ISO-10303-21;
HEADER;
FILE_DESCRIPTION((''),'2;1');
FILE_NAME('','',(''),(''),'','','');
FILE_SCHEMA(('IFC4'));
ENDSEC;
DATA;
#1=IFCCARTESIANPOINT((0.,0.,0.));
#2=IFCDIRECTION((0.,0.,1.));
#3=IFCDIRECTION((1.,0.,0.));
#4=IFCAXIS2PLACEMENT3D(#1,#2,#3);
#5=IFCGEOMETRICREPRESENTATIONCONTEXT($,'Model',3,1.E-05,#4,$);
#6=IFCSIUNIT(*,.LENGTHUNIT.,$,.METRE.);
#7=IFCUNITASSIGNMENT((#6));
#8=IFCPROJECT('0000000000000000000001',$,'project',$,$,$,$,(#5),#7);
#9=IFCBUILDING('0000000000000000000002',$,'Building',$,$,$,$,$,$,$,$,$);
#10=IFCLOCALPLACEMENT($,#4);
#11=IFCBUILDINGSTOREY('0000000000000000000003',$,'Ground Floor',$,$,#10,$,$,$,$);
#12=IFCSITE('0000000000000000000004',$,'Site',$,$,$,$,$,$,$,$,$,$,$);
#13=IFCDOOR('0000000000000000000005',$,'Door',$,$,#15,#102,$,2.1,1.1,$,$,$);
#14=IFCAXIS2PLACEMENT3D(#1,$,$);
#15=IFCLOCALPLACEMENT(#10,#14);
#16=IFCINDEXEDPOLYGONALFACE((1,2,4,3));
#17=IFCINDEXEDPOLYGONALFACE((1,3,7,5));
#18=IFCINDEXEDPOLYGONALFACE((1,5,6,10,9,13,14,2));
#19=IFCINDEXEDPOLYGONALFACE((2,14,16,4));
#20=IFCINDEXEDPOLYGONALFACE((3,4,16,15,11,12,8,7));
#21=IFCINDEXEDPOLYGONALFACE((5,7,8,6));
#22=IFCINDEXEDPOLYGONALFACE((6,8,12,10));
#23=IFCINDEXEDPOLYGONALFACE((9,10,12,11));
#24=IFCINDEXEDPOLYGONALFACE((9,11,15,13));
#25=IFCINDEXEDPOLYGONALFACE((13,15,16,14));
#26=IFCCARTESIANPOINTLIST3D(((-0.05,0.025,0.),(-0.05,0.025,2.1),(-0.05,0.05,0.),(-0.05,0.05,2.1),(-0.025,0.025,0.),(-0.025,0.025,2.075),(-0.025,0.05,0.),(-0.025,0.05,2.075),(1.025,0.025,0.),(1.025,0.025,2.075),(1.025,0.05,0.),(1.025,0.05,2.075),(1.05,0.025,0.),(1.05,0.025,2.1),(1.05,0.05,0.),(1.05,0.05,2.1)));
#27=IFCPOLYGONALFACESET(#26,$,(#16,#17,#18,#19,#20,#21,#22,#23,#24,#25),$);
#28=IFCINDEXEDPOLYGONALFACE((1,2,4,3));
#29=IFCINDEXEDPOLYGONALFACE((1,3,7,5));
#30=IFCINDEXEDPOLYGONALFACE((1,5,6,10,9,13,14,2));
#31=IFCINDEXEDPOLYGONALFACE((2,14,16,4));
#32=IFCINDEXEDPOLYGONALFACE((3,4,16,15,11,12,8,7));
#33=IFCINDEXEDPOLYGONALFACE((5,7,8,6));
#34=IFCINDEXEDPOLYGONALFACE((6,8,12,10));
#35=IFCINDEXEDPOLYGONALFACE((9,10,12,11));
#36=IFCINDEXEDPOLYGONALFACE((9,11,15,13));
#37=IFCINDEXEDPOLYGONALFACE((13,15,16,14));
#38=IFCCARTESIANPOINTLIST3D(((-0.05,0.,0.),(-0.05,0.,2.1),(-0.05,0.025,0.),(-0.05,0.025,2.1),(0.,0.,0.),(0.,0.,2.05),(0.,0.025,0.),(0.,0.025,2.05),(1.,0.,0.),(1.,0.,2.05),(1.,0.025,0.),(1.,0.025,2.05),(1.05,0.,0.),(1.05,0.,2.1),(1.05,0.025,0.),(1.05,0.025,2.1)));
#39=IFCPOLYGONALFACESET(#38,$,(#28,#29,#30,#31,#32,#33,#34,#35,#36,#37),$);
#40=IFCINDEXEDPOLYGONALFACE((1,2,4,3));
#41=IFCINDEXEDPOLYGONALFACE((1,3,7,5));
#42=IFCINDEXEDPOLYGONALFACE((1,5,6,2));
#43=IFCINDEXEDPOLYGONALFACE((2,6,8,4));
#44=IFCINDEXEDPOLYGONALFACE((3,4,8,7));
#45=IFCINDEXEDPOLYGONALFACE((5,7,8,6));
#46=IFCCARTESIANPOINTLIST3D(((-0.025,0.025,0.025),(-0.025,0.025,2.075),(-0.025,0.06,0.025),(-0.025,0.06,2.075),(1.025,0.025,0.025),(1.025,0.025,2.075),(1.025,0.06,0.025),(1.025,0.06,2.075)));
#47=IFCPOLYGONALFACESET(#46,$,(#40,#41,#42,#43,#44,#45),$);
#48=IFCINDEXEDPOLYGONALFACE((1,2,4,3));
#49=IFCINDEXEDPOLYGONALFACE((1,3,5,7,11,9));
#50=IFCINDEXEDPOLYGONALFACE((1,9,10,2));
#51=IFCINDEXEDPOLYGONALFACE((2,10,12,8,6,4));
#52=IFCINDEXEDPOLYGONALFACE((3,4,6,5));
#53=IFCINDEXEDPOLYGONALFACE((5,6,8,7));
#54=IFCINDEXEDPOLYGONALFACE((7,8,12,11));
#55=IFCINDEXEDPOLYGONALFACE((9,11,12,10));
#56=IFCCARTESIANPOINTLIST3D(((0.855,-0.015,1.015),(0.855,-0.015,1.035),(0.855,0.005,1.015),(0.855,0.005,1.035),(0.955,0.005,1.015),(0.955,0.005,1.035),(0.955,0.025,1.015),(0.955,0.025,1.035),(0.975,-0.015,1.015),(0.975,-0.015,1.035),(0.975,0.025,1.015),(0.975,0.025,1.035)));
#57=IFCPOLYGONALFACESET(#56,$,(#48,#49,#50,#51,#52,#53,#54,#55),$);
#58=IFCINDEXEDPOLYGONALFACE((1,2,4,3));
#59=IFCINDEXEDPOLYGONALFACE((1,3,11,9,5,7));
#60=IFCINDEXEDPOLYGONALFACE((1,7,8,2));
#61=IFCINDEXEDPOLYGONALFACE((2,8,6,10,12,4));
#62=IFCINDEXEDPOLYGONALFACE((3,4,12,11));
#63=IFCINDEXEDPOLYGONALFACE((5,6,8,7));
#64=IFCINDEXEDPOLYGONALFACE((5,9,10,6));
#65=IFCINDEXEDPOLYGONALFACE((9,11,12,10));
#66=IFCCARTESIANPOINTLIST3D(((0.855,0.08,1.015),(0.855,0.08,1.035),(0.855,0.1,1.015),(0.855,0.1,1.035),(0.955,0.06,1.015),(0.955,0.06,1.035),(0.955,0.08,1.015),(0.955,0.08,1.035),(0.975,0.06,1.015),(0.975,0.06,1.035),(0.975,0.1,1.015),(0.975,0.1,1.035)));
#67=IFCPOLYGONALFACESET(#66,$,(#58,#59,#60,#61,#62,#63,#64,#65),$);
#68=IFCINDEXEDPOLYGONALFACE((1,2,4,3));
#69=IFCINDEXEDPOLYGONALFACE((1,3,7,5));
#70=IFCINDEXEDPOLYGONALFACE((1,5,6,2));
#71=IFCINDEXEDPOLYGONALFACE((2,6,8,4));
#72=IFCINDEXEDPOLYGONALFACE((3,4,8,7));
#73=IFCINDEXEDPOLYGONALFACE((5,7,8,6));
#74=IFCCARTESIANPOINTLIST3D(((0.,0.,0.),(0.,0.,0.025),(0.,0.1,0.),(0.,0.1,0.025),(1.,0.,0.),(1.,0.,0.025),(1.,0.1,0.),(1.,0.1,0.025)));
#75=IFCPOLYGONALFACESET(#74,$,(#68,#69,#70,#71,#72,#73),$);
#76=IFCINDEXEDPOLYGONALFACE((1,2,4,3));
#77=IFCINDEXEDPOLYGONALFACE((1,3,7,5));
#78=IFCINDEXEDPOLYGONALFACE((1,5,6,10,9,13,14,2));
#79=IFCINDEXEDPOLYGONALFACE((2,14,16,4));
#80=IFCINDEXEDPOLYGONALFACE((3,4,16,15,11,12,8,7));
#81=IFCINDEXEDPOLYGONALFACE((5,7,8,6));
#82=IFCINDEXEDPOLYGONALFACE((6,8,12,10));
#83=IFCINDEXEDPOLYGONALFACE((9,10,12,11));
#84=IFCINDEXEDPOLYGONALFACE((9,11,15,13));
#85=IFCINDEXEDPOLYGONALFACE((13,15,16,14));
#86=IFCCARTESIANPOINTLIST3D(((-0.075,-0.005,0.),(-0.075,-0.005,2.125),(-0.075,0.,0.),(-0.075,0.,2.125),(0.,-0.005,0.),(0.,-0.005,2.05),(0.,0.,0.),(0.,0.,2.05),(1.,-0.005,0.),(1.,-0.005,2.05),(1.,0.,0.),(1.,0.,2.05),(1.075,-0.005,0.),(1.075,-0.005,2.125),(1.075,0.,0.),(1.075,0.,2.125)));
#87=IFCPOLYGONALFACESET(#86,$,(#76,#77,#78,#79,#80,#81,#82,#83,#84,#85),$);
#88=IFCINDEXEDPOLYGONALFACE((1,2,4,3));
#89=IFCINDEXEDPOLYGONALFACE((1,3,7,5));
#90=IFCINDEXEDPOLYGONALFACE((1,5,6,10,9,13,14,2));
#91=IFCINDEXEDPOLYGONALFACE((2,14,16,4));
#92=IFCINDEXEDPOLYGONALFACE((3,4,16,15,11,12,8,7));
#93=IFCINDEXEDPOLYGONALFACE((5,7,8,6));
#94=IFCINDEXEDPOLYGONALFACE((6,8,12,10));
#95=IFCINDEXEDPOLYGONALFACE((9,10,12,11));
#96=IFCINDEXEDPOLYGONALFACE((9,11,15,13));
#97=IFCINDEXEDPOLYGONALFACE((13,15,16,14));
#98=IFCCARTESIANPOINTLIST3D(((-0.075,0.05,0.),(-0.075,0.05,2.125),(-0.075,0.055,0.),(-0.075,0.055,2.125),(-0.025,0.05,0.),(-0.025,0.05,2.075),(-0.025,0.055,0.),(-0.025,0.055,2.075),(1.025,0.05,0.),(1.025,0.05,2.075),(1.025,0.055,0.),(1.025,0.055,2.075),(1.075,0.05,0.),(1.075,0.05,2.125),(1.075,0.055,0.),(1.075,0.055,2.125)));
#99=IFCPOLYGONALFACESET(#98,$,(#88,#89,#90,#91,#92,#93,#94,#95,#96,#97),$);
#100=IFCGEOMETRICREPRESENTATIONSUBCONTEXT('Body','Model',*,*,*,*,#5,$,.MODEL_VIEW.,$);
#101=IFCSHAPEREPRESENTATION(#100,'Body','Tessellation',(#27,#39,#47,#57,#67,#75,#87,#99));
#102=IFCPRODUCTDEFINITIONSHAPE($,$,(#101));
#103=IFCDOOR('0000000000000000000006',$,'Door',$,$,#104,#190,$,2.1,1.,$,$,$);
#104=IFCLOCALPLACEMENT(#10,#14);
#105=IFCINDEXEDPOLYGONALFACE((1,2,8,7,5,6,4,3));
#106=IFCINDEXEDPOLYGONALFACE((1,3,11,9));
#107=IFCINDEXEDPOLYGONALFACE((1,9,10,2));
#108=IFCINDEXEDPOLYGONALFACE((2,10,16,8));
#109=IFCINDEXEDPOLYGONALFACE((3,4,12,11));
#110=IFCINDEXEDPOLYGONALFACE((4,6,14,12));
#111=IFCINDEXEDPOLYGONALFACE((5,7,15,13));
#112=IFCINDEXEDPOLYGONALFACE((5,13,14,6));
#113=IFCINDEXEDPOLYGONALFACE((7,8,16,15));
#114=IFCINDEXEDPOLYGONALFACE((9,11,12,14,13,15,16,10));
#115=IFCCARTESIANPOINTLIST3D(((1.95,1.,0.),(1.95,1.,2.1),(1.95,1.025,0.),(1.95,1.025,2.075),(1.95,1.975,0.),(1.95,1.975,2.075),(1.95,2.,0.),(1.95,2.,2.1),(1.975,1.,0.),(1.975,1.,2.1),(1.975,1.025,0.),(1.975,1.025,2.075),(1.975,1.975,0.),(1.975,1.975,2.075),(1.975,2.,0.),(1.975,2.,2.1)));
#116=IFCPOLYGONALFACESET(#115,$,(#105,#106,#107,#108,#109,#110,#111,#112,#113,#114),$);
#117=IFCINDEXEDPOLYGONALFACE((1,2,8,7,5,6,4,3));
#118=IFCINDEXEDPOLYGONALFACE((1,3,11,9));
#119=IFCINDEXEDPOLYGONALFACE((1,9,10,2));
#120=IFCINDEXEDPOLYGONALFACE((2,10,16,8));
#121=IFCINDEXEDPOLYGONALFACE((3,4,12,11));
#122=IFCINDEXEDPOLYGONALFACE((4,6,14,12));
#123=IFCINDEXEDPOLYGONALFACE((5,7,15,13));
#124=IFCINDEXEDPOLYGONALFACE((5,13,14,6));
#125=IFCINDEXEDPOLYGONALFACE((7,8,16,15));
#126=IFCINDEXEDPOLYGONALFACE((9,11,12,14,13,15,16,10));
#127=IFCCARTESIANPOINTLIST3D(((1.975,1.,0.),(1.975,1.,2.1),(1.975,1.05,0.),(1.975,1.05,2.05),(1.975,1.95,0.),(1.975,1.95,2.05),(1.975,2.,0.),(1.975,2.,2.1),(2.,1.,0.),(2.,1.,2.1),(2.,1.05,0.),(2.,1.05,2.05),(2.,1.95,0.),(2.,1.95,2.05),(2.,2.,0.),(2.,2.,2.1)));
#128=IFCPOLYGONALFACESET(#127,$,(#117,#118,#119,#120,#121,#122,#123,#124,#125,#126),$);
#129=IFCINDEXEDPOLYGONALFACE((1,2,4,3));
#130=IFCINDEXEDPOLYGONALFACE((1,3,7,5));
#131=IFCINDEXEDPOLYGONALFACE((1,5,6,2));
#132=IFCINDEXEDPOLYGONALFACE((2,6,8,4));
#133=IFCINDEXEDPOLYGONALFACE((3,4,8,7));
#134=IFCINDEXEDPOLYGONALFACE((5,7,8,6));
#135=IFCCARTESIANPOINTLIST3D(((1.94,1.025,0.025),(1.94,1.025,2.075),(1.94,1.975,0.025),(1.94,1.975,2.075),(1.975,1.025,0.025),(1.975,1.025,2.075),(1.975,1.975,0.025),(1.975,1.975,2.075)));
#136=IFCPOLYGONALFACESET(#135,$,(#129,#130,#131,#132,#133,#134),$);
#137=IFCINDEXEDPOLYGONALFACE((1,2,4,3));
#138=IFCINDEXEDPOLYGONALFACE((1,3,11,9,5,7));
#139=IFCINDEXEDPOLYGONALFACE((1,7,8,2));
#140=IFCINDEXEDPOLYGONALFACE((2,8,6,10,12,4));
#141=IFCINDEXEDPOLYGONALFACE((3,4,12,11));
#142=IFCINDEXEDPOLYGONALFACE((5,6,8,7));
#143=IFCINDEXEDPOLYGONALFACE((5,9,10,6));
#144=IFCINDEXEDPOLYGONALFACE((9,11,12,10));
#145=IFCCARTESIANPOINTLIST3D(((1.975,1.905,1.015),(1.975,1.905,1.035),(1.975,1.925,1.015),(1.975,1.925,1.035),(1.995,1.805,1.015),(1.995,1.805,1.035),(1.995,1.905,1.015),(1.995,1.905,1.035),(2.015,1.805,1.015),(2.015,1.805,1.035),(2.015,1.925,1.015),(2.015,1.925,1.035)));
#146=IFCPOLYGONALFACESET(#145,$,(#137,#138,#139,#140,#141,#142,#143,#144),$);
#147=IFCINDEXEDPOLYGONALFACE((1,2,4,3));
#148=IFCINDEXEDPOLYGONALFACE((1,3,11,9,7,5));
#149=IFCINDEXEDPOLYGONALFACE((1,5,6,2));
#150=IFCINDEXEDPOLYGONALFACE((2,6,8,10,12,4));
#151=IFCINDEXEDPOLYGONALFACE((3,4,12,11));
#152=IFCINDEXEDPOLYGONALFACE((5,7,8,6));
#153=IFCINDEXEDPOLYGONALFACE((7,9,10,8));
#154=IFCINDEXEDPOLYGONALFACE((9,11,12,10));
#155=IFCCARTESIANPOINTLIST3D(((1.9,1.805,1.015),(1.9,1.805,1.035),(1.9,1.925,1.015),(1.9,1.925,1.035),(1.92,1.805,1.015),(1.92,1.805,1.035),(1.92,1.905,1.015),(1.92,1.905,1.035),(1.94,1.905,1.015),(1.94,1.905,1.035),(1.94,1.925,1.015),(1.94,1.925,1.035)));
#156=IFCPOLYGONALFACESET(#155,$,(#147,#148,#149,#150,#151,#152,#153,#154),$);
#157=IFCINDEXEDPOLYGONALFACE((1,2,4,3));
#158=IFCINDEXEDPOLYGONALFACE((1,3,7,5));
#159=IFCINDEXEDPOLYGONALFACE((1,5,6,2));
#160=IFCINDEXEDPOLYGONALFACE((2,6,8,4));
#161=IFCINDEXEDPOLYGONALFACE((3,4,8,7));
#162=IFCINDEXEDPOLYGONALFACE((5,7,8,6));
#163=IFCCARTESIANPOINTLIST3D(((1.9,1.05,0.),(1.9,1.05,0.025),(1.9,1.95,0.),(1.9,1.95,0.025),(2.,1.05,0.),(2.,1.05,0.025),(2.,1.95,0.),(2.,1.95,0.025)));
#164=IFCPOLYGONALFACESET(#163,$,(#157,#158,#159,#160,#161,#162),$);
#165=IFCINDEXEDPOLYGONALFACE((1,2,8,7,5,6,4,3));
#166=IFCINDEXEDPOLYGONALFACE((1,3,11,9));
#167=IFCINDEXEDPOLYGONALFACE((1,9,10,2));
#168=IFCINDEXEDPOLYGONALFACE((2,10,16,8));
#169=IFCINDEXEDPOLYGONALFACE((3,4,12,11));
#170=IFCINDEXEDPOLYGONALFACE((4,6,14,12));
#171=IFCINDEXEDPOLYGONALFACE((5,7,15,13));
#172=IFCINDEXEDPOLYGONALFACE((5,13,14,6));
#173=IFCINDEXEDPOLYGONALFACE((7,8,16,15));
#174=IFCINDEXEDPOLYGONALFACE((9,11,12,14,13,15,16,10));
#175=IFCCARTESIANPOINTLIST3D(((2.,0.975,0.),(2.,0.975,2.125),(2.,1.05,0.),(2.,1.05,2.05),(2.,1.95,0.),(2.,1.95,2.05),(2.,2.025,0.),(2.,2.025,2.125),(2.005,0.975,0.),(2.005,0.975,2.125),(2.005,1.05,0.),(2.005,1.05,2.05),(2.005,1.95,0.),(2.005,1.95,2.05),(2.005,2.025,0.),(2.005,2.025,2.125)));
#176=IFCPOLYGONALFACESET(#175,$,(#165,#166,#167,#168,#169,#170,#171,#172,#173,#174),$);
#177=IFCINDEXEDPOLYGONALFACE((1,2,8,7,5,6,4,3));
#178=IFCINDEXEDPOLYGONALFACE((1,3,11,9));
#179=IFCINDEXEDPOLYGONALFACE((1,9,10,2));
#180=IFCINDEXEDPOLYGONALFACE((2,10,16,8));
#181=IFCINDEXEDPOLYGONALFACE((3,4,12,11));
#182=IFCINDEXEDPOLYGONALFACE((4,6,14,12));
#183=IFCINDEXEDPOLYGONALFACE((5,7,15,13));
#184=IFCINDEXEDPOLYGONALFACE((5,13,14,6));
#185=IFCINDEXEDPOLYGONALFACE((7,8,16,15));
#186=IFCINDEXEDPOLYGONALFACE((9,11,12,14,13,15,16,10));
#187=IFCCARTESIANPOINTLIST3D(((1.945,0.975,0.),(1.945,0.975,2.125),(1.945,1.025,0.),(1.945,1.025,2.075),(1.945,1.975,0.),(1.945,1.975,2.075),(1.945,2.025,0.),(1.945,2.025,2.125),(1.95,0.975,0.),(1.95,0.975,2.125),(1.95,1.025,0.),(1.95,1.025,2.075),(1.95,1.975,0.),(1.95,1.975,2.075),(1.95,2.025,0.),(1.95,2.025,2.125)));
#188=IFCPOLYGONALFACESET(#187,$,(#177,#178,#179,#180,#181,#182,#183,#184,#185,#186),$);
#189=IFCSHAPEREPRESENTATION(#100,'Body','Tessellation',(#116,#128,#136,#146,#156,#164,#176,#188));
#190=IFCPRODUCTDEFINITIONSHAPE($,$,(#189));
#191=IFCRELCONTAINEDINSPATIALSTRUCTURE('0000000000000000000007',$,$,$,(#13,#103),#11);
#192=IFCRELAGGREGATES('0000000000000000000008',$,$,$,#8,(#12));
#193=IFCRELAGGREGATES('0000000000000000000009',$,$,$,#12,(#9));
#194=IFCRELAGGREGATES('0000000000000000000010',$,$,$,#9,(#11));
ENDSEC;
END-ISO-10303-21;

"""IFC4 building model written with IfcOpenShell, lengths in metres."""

from ifc_helpers import new_model, si_unit, frame, origin_with_axes, place, context, subcontext, project, spatial, line, indexed_curve, outline, extrude, element, save


model = new_model("IFC4")

# Units and contexts
model_context = context("Model", 3, precision=1e-05, world=origin_with_axes())
body_context = subcontext(model_context, "Body", "Model", "MODEL_VIEW")
ifc_project = project(units=[si_unit("LENGTHUNIT", "METRE")], contexts=[model_context])

# Site, building, storey
site = spatial("IfcSite", under=ifc_project, Name="Site")
building = spatial("IfcBuilding", under=site, Name="Building")
storey_placement = place(None, origin_with_axes())
storey = spatial("IfcBuildingStorey", under=building, at=storey_placement, Name="Ground Floor")

# Doors
door_1_placement = place(storey_placement, frame((-0.05, 0.0, 0.0), z_axis=(0.0, 0.0, 1.0), x_axis=(1.0, 0.0, 0.0)))
element("IfcDoor", 1, at=door_1_placement, inside=storey, Name="Door", OverallHeight=2.1, OverallWidth=1.1, context=body_context, shape_type="SweptSolid", body=[
    extrude(outline(indexed_curve([(0.0, 0.0), (0.0, 2.1), (1.1, 2.1), (1.1, 0.0), (1.075, 0.0), (1.075, 2.075), (0.025, 2.075), (0.025, 0.0)], segments=[line(1, 2, 3, 4, 5, 6, 7, 8, 1)])), frame((0.0, 0.025, 0.0), z_axis=(0.0, -1.0, 0.0), x_axis=(1.0, 0.0, 0.0)), (0.0, 0.0, -1.0), 0.025),
    extrude(outline(indexed_curve([(0.0, 0.0), (0.0, 2.1), (1.1, 2.1), (1.1, 0.0), (1.05, 0.0), (1.05, 2.05), (0.05, 2.05), (0.05, 0.0)], segments=[line(1, 2, 3, 4, 5, 6, 7, 8, 1)])), frame((0.0, 0.0, 0.0), z_axis=(0.0, -1.0, 0.0), x_axis=(1.0, 0.0, 0.0)), (0.0, 0.0, -1.0), 0.025),
    extrude(outline(indexed_curve([(0.0, 0.0), (1.05, 0.0), (1.05, 0.035), (0.0, 0.035)], segments=[line(1, 2, 3, 4, 1)])), frame((0.025, 0.025, 0.025), z_axis=(0.0, 0.0, 1.0), x_axis=(1.0, 0.0, 0.0)), (0.0, 0.0, 1.0), 2.05),
    extrude(outline(indexed_curve([(0.0, 0.0), (0.0, -0.04), (-0.12, -0.04), (-0.12, -0.02), (-0.02, -0.02), (-0.02, 0.0)], segments=[line(1, 2, 3, 4, 5, 6, 1)])), frame((1.025, 0.025, 1.015), z_axis=(0.0, 0.0, 1.0), x_axis=(1.0, 0.0, 0.0)), (0.0, 0.0, 1.0), 0.02),
    extrude(outline(indexed_curve([(0.0, 0.0), (0.0, 0.04), (-0.12, 0.04), (-0.12, 0.02), (-0.02, 0.02), (-0.02, 0.0)], segments=[line(1, 2, 3, 4, 5, 6, 1)])), frame((1.025, 0.06, 1.015), z_axis=(0.0, 0.0, 1.0), x_axis=(1.0, 0.0, 0.0)), (0.0, 0.0, 1.0), 0.02),
    extrude(outline(indexed_curve([(0.0, 0.0), (1.0, 0.0), (1.0, 0.1), (0.0, 0.1)], segments=[line(1, 2, 3, 4, 1)])), frame((0.05, 0.0, 0.0), z_axis=(0.0, 0.0, 1.0), x_axis=(1.0, 0.0, 0.0)), (0.0, 0.0, 1.0), 0.025),
    extrude(outline(indexed_curve([(0.0, 0.0), (0.0, 2.125), (1.15, 2.125), (1.15, 0.0), (1.075, 0.0), (1.075, 2.05), (0.075, 2.05), (0.075, 0.0)], segments=[line(1, 2, 3, 4, 5, 6, 7, 8, 1)])), frame((-0.025, -0.005, 0.0), z_axis=(0.0, -1.0, 0.0), x_axis=(1.0, 0.0, 0.0)), (0.0, 0.0, -1.0), 0.005),
    extrude(outline(indexed_curve([(0.0, 0.0), (0.0, 2.125), (1.15, 2.125), (1.15, 0.0), (1.1, 0.0), (1.1, 2.075), (0.05, 2.075), (0.05, 0.0)], segments=[line(1, 2, 3, 4, 5, 6, 7, 8, 1)])), frame((-0.025, 0.05, 0.0), z_axis=(0.0, -1.0, 0.0), x_axis=(1.0, 0.0, 0.0)), (0.0, 0.0, -1.0), 0.005),
])
door_2_placement = place(storey_placement, frame((2.0, 1.0, 0.0), z_axis=(0.0, 0.0, 1.0), x_axis=(0.0, 1.0, 0.0)))
element("IfcDoor", 2, at=door_2_placement, inside=storey, Name="Door", OverallHeight=2.1, OverallWidth=1.0, context=body_context, shape_type="SweptSolid", body=[
    extrude(outline(indexed_curve([(0.0, 0.0), (0.0, 2.1), (1.0, 2.1), (1.0, 0.0), (0.975, 0.0), (0.975, 2.075), (0.025, 2.075), (0.025, 0.0)], segments=[line(1, 2, 3, 4, 5, 6, 7, 8, 1)])), frame((0.0, 0.025, 0.0), z_axis=(0.0, -1.0, 0.0), x_axis=(1.0, 0.0, 0.0)), (0.0, 0.0, -1.0), 0.025),
    extrude(outline(indexed_curve([(0.0, 0.0), (0.0, 2.1), (1.0, 2.1), (1.0, 0.0), (0.95, 0.0), (0.95, 2.05), (0.05, 2.05), (0.05, 0.0)], segments=[line(1, 2, 3, 4, 5, 6, 7, 8, 1)])), frame((0.0, 0.0, 0.0), z_axis=(0.0, -1.0, 0.0), x_axis=(1.0, 0.0, 0.0)), (0.0, 0.0, -1.0), 0.025),
    extrude(outline(indexed_curve([(0.0, 0.0), (0.95, 0.0), (0.95, 0.035), (0.0, 0.035)], segments=[line(1, 2, 3, 4, 1)])), frame((0.025, 0.025, 0.025), z_axis=(0.0, 0.0, 1.0), x_axis=(1.0, 0.0, 0.0)), (0.0, 0.0, 1.0), 2.05),
    extrude(outline(indexed_curve([(0.0, 0.0), (0.0, -0.04), (-0.12, -0.04), (-0.12, -0.02), (-0.02, -0.02), (-0.02, 0.0)], segments=[line(1, 2, 3, 4, 5, 6, 1)])), frame((0.925, 0.025, 1.015), z_axis=(0.0, 0.0, 1.0), x_axis=(1.0, 0.0, 0.0)), (0.0, 0.0, 1.0), 0.02),
    extrude(outline(indexed_curve([(0.0, 0.0), (0.0, 0.04), (-0.12, 0.04), (-0.12, 0.02), (-0.02, 0.02), (-0.02, 0.0)], segments=[line(1, 2, 3, 4, 5, 6, 1)])), frame((0.925, 0.06, 1.015), z_axis=(0.0, 0.0, 1.0), x_axis=(1.0, 0.0, 0.0)), (0.0, 0.0, 1.0), 0.02),
    extrude(outline(indexed_curve([(0.0, 0.0), (0.9, 0.0), (0.9, 0.1), (0.0, 0.1)], segments=[line(1, 2, 3, 4, 1)])), frame((0.05, 0.0, 0.0), z_axis=(0.0, 0.0, 1.0), x_axis=(1.0, 0.0, 0.0)), (0.0, 0.0, 1.0), 0.025),
    extrude(outline(indexed_curve([(0.0, 0.0), (0.0, 2.125), (1.05, 2.125), (1.05, 0.0), (0.975, 0.0), (0.975, 2.05), (0.075, 2.05), (0.075, 0.0)], segments=[line(1, 2, 3, 4, 5, 6, 7, 8, 1)])), frame((-0.025, -0.005, 0.0), z_axis=(0.0, -1.0, 0.0), x_axis=(1.0, 0.0, 0.0)), (0.0, 0.0, -1.0), 0.005),
    extrude(outline(indexed_curve([(0.0, 0.0), (0.0, 2.125), (1.05, 2.125), (1.05, 0.0), (1.0, 0.0), (1.0, 2.075), (0.05, 2.075), (0.05, 0.0)], segments=[line(1, 2, 3, 4, 5, 6, 7, 8, 1)])), frame((-0.025, 0.05, 0.0), z_axis=(0.0, -1.0, 0.0), x_axis=(1.0, 0.0, 0.0)), (0.0, 0.0, -1.0), 0.005),
])

save(model, "model.ifc")
